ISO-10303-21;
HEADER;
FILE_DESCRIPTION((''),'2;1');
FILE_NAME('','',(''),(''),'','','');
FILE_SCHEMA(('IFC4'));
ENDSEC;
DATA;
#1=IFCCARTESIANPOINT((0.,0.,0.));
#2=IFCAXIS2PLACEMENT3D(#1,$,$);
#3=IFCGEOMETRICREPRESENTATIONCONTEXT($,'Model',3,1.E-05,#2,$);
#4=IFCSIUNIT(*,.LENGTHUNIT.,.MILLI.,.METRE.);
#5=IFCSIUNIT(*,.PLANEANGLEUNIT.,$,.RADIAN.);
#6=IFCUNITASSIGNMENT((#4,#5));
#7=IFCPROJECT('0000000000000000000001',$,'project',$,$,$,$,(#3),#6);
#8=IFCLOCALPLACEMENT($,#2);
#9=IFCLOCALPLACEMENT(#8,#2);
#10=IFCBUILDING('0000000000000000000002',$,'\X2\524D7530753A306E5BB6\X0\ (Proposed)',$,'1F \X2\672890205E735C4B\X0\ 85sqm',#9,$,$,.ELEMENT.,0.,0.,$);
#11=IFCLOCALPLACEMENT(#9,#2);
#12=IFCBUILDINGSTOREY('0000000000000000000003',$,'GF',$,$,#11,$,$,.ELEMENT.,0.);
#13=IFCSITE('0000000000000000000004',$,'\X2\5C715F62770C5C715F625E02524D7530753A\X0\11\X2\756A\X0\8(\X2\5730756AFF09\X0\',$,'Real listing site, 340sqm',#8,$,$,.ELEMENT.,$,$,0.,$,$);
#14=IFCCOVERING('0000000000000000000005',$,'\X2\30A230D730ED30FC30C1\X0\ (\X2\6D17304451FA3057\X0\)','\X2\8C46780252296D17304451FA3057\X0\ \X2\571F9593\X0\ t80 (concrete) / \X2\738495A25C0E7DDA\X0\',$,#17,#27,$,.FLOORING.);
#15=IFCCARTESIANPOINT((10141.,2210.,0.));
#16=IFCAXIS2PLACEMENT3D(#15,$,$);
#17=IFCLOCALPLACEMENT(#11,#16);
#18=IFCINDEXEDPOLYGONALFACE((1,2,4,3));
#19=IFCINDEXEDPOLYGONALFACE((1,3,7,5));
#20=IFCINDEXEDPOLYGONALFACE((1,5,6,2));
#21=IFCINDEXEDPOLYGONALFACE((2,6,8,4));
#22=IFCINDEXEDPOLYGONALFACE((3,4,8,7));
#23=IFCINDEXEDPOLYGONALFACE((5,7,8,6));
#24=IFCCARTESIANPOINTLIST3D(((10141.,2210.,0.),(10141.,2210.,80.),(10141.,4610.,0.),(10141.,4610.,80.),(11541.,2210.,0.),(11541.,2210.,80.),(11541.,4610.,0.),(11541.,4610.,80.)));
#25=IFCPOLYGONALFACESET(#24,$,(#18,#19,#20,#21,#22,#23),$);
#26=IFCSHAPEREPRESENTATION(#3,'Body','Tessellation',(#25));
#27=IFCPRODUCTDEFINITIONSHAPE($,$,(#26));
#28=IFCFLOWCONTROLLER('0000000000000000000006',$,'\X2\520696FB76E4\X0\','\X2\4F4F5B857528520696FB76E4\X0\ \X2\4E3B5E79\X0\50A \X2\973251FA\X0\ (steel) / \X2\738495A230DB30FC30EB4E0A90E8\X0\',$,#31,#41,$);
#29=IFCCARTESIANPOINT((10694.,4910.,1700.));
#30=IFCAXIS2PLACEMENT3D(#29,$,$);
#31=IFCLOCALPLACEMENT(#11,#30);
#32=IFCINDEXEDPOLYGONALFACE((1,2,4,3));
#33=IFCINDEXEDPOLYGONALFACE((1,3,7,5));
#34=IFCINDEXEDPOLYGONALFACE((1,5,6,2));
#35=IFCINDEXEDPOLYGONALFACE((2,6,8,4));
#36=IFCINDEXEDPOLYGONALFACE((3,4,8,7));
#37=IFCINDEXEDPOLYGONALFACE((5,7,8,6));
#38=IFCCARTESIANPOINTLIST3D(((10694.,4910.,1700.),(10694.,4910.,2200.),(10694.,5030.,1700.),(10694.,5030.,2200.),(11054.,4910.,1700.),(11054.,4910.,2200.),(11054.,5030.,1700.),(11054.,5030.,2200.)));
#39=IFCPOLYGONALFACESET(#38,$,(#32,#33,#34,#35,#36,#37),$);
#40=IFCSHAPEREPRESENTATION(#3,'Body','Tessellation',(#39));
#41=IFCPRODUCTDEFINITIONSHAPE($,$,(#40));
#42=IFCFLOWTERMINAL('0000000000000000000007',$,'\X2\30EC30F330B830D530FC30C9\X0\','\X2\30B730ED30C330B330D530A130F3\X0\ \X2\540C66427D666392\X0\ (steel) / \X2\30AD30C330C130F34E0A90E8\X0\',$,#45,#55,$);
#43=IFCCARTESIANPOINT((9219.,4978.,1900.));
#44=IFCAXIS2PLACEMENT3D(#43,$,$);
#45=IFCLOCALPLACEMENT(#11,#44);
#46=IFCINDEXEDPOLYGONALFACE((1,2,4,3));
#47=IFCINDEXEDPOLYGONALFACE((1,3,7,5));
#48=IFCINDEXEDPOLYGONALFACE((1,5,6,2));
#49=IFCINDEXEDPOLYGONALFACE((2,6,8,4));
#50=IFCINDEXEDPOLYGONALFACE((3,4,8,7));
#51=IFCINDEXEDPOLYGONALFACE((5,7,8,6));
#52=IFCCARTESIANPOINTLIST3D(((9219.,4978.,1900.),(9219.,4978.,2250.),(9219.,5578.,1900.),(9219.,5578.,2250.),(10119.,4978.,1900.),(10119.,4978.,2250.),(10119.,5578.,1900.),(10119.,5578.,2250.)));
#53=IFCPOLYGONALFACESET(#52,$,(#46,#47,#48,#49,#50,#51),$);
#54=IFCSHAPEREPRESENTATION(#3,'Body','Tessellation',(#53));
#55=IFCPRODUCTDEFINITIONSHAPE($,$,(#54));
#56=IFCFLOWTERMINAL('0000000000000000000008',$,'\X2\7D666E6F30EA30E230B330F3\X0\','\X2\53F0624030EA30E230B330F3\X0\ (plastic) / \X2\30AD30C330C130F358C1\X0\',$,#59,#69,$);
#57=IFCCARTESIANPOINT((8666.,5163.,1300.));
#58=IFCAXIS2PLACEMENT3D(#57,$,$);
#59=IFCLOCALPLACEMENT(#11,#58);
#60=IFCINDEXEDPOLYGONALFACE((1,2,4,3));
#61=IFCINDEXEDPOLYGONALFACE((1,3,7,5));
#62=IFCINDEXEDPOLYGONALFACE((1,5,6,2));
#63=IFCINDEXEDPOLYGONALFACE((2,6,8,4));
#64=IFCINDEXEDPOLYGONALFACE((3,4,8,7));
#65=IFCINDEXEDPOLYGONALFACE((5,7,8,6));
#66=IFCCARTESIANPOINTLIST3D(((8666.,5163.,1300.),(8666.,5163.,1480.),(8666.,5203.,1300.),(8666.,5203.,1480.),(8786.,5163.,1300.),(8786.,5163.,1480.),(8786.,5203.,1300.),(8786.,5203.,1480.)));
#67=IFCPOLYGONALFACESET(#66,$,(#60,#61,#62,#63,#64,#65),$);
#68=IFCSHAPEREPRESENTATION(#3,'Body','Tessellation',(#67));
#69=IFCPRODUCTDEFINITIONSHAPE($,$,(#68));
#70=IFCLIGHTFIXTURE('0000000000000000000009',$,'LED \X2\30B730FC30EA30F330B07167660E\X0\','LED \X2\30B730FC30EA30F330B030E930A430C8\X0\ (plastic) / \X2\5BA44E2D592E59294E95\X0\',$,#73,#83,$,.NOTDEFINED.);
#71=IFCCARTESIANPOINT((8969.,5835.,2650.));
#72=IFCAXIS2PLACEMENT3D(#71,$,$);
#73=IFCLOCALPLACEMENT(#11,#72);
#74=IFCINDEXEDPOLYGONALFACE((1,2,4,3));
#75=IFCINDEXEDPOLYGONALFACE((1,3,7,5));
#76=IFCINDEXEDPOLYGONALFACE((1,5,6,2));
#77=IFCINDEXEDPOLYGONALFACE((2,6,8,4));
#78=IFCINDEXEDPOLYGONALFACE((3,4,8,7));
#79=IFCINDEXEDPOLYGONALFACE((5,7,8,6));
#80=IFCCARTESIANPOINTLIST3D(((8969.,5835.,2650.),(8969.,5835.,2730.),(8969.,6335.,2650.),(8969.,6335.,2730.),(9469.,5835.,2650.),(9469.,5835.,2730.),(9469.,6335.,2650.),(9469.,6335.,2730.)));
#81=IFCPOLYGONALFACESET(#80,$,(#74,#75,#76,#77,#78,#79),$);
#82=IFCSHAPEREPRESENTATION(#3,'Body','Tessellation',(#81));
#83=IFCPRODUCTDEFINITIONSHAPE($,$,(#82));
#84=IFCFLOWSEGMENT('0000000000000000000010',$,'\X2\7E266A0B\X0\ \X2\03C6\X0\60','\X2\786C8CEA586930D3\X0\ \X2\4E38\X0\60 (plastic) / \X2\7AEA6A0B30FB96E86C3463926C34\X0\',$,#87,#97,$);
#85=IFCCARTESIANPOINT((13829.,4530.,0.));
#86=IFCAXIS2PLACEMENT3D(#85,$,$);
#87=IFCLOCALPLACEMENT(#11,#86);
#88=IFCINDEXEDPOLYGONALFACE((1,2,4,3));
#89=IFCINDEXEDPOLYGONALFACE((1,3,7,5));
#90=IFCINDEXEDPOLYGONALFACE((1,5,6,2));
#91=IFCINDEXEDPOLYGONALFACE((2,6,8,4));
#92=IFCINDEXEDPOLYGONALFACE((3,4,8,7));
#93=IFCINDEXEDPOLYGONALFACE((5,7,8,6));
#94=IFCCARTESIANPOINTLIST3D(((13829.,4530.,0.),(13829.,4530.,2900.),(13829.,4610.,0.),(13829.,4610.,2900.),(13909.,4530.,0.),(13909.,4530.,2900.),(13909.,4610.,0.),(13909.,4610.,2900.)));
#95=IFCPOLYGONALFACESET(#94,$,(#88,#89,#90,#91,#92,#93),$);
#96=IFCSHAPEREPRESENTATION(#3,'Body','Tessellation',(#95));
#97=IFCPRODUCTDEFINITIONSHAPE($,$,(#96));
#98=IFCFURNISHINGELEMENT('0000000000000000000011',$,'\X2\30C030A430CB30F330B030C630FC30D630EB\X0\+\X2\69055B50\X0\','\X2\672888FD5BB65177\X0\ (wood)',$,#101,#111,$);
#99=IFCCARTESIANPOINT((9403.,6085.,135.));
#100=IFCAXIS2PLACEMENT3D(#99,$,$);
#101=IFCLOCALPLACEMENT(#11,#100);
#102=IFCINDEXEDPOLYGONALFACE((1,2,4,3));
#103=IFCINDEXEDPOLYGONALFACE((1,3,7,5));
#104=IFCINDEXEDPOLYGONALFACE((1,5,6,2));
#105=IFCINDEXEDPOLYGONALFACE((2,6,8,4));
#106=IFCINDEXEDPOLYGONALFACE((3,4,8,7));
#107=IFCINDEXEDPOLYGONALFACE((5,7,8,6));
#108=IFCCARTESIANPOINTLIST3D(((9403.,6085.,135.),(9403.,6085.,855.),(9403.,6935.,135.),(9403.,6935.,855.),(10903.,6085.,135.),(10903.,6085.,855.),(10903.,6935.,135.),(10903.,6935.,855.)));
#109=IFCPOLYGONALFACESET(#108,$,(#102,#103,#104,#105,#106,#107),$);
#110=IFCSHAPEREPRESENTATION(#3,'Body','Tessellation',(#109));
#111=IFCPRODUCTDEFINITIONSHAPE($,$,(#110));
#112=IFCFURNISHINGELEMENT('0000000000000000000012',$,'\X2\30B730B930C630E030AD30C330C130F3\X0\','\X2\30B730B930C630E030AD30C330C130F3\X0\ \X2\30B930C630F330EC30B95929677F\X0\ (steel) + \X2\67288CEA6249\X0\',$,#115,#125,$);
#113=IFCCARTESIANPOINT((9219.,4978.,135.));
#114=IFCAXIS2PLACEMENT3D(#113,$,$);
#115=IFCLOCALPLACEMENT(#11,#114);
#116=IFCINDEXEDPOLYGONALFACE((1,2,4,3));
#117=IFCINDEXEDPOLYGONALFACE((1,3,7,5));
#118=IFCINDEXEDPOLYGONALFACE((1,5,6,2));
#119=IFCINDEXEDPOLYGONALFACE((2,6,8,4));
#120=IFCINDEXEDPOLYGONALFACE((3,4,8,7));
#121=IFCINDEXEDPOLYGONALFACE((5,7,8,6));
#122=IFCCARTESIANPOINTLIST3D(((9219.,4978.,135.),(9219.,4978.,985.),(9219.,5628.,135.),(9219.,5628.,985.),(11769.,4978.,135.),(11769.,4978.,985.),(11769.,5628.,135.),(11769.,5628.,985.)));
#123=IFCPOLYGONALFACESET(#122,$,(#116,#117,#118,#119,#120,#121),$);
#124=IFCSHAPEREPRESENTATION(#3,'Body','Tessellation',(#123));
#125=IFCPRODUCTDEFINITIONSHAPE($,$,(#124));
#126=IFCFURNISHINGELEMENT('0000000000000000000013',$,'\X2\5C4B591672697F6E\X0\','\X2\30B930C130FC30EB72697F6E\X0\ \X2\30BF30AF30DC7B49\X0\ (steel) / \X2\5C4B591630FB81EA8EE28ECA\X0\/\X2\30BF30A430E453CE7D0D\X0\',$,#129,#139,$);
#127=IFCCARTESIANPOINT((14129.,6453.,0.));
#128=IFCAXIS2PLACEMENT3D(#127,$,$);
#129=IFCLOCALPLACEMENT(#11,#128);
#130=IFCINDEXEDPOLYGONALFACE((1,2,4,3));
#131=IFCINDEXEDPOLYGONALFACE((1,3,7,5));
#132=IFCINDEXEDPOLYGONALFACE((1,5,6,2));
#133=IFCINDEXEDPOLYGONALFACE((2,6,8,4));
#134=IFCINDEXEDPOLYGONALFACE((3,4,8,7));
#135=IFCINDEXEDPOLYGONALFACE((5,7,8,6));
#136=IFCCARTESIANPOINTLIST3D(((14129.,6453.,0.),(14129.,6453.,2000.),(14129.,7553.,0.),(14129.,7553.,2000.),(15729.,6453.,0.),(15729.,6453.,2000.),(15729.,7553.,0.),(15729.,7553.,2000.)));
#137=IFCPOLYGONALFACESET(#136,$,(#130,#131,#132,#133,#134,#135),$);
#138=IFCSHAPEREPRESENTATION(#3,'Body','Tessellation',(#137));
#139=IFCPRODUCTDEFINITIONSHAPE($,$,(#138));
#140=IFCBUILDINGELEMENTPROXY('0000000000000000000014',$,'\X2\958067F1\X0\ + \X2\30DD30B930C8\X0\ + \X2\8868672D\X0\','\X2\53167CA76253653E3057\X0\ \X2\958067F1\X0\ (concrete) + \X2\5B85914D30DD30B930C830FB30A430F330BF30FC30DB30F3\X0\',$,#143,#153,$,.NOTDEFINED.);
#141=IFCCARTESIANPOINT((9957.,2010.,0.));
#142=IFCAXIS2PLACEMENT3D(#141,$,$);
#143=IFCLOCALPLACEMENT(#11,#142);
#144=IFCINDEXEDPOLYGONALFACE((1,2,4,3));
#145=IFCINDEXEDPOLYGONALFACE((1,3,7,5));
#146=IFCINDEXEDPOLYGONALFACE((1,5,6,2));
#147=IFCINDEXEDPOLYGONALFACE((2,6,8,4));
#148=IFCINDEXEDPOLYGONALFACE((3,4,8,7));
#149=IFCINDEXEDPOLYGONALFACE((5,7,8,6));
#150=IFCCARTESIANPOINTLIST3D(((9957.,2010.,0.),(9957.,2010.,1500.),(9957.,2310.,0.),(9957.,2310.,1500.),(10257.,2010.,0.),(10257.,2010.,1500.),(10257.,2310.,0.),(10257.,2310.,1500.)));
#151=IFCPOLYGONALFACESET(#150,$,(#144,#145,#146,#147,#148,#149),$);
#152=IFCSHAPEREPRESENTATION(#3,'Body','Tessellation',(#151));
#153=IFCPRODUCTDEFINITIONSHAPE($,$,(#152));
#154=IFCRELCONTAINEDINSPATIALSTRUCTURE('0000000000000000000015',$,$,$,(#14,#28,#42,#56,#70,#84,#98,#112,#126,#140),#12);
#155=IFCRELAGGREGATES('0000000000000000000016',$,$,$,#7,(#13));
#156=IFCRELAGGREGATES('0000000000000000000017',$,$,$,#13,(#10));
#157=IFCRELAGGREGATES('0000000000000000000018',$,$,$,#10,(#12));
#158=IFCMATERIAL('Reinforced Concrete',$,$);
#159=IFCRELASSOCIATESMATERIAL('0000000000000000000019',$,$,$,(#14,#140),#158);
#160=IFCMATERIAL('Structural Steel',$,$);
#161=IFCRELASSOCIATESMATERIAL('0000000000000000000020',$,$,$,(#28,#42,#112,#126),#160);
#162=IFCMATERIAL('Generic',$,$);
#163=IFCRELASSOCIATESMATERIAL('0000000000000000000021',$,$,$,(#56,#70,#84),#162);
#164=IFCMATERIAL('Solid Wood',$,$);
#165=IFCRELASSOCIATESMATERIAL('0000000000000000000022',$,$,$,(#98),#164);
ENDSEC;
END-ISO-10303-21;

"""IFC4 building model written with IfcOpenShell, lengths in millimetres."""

from ifc_helpers import new_model, si_unit, frame, frame_2d, origin, place, context, project, spatial, rectangle, extrude, material, element, save


model = new_model("IFC4")

# Units and contexts
model_context = context("Model", 3, precision=1e-05, world=origin())
ifc_project = project(units=[si_unit("LENGTHUNIT", "METRE", prefix="MILLI"), si_unit("PLANEANGLEUNIT", "RADIAN")], contexts=[model_context])

# Site, building, storey
site_placement = place(None, origin())
site = spatial("IfcSite", under=ifc_project, at=site_placement, Name="山形県山形市前田町11番8(地番）", ObjectType="Real listing site, 340sqm", CompositionType="ELEMENT", RefElevation=0.0)
building_placement = place(site_placement, origin())
building = spatial("IfcBuilding", under=site, at=building_placement, Name="前田町の家 (Proposed)", ObjectType="1F 木造平屋 85sqm", CompositionType="ELEMENT", ElevationOfRefHeight=0.0, ElevationOfTerrain=0.0)
storey_placement = place(building_placement, origin())
storey = spatial("IfcBuildingStorey", under=building, at=storey_placement, Name="GF", CompositionType="ELEMENT", Elevation=0.0)

# Shared definitions
ifc_material_1 = material(Name="Solid Wood")

# Shared definitions
ifc_material_2 = material(Name="Structural Steel")

# Covering
ifc_material_3 = material(Name="Reinforced Concrete")
covering_placement = place(storey_placement, frame((10141.0, 2210.0, 0.0)))
element("IfcCovering", 1, at=covering_placement, inside=storey, material=ifc_material_3, Name="アプローチ (洗い出し)", Description="豆砂利洗い出し 土間 t80 (concrete) / 玄関導線", PredefinedType="FLOORING", context=model_context, shape_type="SweptSolid", body=[
    extrude(rectangle(XDim=1400.0, YDim=2400.0, at=frame_2d((700.0, 1200.0))), frame((10141.0, 2210.0, 0.0)), (0.0, 0.0, 1.0), 80.0),
])

# Flow controller
flow_controller_placement = place(storey_placement, frame((10694.0, 4910.0, 1700.0)))
element("IfcFlowController", 2, at=flow_controller_placement, inside=storey, material=ifc_material_2, Name="分電盤", Description="住宅用分電盤 主幹50A 露出 (steel) / 玄関ホール上部", context=model_context, shape_type="SweptSolid", body=[
    extrude(rectangle(XDim=360.0, YDim=120.0, at=frame_2d((180.0, 60.0))), frame((10694.0, 4910.0, 1700.0)), (0.0, 0.0, 1.0), 500.0),
])

# Flow terminals
flow_terminal_1_placement = place(storey_placement, frame((9219.0, 4978.0, 1900.0)))
element("IfcFlowTerminal", 3, at=flow_terminal_1_placement, inside=storey, material=ifc_material_2, Name="レンジフード", Description="シロッコファン 同時給排 (steel) / キッチン上部", context=model_context, shape_type="SweptSolid", body=[
    extrude(rectangle(XDim=900.0, YDim=600.0, at=frame_2d((450.0, 300.0))), frame((9219.0, 4978.0, 1900.0)), (0.0, 0.0, 1.0), 350.0),
])
ifc_material_4 = material(Name="Generic")
flow_terminal_2_placement = place(storey_placement, frame((8666.0, 5163.0, 1300.0)))
element("IfcFlowTerminal", 4, at=flow_terminal_2_placement, inside=storey, material=ifc_material_4, Name="給湯リモコン", Description="台所リモコン (plastic) / キッチン壁", context=model_context, shape_type="SweptSolid", body=[
    extrude(rectangle(XDim=120.0, YDim=40.0, at=frame_2d((60.0, 20.0))), frame((8666.0, 5163.0, 1300.0)), (0.0, 0.0, 1.0), 180.0),
])

# Light fixture
light_fixture_placement = place(storey_placement, frame((8969.0, 5835.0, 2650.0)))
element("IfcLightFixture", 5, at=light_fixture_placement, inside=storey, material=ifc_material_4, Name="LED シーリング照明", Description="LED シーリングライト (plastic) / 室中央天井", PredefinedType="NOTDEFINED", context=model_context, shape_type="SweptSolid", body=[
    extrude(rectangle(XDim=500.0, YDim=500.0, at=frame_2d((250.0, 250.0))), frame((8969.0, 5835.0, 2650.0)), (0.0, 0.0, 1.0), 80.0),
])

# Flow segment
flow_segment_placement = place(storey_placement, frame((13829.0, 4530.0, 0.0)))
element("IfcFlowSegment", 6, at=flow_segment_placement, inside=storey, material=ifc_material_4, Name="縦樋 φ60", Description="硬質塩ビ 丸60 (plastic) / 竪樋・雨水排水", context=model_context, shape_type="SweptSolid", body=[
    extrude(rectangle(XDim=80.0, YDim=80.0, at=frame_2d((40.0, 40.0))), frame((13829.0, 4530.0, 0.0)), (0.0, 0.0, 1.0), 2900.0),
])

# Furnishing elements
furnishing_1_placement = place(storey_placement, frame((9403.0, 6085.0, 135.0)))
element("IfcFurnishingElement", 7, at=furnishing_1_placement, inside=storey, material=ifc_material_1, Name="ダイニングテーブル+椅子", Description="木製家具 (wood)", context=model_context, shape_type="SweptSolid", body=[
    extrude(rectangle(XDim=1500.0, YDim=850.0, at=frame_2d((750.0, 425.0))), frame((9403.0, 6085.0, 135.0)), (0.0, 0.0, 1.0), 720.0),
])
furnishing_2_placement = place(storey_placement, frame((9219.0, 4978.0, 135.0)))
element("IfcFurnishingElement", 8, at=furnishing_2_placement, inside=storey, material=ifc_material_2, Name="システムキッチン", Description="システムキッチン ステンレス天板 (steel) + 木質扉", context=model_context, shape_type="SweptSolid", body=[
    extrude(rectangle(XDim=2550.0, YDim=650.0, at=frame_2d((1275.0, 325.0))), frame((9219.0, 4978.0, 135.0)), (0.0, 0.0, 1.0), 850.0),
])
furnishing_3_placement = place(storey_placement, frame((14129.0, 6453.0, 0.0)))
element("IfcFurnishingElement", 9, at=furnishing_3_placement, inside=storey, material=ifc_material_2, Name="屋外物置", Description="スチール物置 タクボ等 (steel) / 屋外・自転車/タイヤ収納", context=model_context, shape_type="SweptSolid", body=[
    extrude(rectangle(XDim=1600.0, YDim=1100.0, at=frame_2d((800.0, 550.0))), frame((14129.0, 6453.0, 0.0)), (0.0, 0.0, 1.0), 2000.0),
])

# Building element proxy
proxy_placement = place(storey_placement, frame((9957.0, 2010.0, 0.0)))
element("IfcBuildingElementProxy", 10, at=proxy_placement, inside=storey, material=ifc_material_3, Name="門柱 + ポスト + 表札", Description="化粧打放し 門柱 (concrete) + 宅配ポスト・インターホン", PredefinedType="NOTDEFINED", context=model_context, shape_type="SweptSolid", body=[
    extrude(rectangle(XDim=300.0, YDim=300.0, at=frame_2d((150.0, 150.0))), frame((9957.0, 2010.0, 0.0)), (0.0, 0.0, 1.0), 1500.0),
])

save(model, "model.ifc")
